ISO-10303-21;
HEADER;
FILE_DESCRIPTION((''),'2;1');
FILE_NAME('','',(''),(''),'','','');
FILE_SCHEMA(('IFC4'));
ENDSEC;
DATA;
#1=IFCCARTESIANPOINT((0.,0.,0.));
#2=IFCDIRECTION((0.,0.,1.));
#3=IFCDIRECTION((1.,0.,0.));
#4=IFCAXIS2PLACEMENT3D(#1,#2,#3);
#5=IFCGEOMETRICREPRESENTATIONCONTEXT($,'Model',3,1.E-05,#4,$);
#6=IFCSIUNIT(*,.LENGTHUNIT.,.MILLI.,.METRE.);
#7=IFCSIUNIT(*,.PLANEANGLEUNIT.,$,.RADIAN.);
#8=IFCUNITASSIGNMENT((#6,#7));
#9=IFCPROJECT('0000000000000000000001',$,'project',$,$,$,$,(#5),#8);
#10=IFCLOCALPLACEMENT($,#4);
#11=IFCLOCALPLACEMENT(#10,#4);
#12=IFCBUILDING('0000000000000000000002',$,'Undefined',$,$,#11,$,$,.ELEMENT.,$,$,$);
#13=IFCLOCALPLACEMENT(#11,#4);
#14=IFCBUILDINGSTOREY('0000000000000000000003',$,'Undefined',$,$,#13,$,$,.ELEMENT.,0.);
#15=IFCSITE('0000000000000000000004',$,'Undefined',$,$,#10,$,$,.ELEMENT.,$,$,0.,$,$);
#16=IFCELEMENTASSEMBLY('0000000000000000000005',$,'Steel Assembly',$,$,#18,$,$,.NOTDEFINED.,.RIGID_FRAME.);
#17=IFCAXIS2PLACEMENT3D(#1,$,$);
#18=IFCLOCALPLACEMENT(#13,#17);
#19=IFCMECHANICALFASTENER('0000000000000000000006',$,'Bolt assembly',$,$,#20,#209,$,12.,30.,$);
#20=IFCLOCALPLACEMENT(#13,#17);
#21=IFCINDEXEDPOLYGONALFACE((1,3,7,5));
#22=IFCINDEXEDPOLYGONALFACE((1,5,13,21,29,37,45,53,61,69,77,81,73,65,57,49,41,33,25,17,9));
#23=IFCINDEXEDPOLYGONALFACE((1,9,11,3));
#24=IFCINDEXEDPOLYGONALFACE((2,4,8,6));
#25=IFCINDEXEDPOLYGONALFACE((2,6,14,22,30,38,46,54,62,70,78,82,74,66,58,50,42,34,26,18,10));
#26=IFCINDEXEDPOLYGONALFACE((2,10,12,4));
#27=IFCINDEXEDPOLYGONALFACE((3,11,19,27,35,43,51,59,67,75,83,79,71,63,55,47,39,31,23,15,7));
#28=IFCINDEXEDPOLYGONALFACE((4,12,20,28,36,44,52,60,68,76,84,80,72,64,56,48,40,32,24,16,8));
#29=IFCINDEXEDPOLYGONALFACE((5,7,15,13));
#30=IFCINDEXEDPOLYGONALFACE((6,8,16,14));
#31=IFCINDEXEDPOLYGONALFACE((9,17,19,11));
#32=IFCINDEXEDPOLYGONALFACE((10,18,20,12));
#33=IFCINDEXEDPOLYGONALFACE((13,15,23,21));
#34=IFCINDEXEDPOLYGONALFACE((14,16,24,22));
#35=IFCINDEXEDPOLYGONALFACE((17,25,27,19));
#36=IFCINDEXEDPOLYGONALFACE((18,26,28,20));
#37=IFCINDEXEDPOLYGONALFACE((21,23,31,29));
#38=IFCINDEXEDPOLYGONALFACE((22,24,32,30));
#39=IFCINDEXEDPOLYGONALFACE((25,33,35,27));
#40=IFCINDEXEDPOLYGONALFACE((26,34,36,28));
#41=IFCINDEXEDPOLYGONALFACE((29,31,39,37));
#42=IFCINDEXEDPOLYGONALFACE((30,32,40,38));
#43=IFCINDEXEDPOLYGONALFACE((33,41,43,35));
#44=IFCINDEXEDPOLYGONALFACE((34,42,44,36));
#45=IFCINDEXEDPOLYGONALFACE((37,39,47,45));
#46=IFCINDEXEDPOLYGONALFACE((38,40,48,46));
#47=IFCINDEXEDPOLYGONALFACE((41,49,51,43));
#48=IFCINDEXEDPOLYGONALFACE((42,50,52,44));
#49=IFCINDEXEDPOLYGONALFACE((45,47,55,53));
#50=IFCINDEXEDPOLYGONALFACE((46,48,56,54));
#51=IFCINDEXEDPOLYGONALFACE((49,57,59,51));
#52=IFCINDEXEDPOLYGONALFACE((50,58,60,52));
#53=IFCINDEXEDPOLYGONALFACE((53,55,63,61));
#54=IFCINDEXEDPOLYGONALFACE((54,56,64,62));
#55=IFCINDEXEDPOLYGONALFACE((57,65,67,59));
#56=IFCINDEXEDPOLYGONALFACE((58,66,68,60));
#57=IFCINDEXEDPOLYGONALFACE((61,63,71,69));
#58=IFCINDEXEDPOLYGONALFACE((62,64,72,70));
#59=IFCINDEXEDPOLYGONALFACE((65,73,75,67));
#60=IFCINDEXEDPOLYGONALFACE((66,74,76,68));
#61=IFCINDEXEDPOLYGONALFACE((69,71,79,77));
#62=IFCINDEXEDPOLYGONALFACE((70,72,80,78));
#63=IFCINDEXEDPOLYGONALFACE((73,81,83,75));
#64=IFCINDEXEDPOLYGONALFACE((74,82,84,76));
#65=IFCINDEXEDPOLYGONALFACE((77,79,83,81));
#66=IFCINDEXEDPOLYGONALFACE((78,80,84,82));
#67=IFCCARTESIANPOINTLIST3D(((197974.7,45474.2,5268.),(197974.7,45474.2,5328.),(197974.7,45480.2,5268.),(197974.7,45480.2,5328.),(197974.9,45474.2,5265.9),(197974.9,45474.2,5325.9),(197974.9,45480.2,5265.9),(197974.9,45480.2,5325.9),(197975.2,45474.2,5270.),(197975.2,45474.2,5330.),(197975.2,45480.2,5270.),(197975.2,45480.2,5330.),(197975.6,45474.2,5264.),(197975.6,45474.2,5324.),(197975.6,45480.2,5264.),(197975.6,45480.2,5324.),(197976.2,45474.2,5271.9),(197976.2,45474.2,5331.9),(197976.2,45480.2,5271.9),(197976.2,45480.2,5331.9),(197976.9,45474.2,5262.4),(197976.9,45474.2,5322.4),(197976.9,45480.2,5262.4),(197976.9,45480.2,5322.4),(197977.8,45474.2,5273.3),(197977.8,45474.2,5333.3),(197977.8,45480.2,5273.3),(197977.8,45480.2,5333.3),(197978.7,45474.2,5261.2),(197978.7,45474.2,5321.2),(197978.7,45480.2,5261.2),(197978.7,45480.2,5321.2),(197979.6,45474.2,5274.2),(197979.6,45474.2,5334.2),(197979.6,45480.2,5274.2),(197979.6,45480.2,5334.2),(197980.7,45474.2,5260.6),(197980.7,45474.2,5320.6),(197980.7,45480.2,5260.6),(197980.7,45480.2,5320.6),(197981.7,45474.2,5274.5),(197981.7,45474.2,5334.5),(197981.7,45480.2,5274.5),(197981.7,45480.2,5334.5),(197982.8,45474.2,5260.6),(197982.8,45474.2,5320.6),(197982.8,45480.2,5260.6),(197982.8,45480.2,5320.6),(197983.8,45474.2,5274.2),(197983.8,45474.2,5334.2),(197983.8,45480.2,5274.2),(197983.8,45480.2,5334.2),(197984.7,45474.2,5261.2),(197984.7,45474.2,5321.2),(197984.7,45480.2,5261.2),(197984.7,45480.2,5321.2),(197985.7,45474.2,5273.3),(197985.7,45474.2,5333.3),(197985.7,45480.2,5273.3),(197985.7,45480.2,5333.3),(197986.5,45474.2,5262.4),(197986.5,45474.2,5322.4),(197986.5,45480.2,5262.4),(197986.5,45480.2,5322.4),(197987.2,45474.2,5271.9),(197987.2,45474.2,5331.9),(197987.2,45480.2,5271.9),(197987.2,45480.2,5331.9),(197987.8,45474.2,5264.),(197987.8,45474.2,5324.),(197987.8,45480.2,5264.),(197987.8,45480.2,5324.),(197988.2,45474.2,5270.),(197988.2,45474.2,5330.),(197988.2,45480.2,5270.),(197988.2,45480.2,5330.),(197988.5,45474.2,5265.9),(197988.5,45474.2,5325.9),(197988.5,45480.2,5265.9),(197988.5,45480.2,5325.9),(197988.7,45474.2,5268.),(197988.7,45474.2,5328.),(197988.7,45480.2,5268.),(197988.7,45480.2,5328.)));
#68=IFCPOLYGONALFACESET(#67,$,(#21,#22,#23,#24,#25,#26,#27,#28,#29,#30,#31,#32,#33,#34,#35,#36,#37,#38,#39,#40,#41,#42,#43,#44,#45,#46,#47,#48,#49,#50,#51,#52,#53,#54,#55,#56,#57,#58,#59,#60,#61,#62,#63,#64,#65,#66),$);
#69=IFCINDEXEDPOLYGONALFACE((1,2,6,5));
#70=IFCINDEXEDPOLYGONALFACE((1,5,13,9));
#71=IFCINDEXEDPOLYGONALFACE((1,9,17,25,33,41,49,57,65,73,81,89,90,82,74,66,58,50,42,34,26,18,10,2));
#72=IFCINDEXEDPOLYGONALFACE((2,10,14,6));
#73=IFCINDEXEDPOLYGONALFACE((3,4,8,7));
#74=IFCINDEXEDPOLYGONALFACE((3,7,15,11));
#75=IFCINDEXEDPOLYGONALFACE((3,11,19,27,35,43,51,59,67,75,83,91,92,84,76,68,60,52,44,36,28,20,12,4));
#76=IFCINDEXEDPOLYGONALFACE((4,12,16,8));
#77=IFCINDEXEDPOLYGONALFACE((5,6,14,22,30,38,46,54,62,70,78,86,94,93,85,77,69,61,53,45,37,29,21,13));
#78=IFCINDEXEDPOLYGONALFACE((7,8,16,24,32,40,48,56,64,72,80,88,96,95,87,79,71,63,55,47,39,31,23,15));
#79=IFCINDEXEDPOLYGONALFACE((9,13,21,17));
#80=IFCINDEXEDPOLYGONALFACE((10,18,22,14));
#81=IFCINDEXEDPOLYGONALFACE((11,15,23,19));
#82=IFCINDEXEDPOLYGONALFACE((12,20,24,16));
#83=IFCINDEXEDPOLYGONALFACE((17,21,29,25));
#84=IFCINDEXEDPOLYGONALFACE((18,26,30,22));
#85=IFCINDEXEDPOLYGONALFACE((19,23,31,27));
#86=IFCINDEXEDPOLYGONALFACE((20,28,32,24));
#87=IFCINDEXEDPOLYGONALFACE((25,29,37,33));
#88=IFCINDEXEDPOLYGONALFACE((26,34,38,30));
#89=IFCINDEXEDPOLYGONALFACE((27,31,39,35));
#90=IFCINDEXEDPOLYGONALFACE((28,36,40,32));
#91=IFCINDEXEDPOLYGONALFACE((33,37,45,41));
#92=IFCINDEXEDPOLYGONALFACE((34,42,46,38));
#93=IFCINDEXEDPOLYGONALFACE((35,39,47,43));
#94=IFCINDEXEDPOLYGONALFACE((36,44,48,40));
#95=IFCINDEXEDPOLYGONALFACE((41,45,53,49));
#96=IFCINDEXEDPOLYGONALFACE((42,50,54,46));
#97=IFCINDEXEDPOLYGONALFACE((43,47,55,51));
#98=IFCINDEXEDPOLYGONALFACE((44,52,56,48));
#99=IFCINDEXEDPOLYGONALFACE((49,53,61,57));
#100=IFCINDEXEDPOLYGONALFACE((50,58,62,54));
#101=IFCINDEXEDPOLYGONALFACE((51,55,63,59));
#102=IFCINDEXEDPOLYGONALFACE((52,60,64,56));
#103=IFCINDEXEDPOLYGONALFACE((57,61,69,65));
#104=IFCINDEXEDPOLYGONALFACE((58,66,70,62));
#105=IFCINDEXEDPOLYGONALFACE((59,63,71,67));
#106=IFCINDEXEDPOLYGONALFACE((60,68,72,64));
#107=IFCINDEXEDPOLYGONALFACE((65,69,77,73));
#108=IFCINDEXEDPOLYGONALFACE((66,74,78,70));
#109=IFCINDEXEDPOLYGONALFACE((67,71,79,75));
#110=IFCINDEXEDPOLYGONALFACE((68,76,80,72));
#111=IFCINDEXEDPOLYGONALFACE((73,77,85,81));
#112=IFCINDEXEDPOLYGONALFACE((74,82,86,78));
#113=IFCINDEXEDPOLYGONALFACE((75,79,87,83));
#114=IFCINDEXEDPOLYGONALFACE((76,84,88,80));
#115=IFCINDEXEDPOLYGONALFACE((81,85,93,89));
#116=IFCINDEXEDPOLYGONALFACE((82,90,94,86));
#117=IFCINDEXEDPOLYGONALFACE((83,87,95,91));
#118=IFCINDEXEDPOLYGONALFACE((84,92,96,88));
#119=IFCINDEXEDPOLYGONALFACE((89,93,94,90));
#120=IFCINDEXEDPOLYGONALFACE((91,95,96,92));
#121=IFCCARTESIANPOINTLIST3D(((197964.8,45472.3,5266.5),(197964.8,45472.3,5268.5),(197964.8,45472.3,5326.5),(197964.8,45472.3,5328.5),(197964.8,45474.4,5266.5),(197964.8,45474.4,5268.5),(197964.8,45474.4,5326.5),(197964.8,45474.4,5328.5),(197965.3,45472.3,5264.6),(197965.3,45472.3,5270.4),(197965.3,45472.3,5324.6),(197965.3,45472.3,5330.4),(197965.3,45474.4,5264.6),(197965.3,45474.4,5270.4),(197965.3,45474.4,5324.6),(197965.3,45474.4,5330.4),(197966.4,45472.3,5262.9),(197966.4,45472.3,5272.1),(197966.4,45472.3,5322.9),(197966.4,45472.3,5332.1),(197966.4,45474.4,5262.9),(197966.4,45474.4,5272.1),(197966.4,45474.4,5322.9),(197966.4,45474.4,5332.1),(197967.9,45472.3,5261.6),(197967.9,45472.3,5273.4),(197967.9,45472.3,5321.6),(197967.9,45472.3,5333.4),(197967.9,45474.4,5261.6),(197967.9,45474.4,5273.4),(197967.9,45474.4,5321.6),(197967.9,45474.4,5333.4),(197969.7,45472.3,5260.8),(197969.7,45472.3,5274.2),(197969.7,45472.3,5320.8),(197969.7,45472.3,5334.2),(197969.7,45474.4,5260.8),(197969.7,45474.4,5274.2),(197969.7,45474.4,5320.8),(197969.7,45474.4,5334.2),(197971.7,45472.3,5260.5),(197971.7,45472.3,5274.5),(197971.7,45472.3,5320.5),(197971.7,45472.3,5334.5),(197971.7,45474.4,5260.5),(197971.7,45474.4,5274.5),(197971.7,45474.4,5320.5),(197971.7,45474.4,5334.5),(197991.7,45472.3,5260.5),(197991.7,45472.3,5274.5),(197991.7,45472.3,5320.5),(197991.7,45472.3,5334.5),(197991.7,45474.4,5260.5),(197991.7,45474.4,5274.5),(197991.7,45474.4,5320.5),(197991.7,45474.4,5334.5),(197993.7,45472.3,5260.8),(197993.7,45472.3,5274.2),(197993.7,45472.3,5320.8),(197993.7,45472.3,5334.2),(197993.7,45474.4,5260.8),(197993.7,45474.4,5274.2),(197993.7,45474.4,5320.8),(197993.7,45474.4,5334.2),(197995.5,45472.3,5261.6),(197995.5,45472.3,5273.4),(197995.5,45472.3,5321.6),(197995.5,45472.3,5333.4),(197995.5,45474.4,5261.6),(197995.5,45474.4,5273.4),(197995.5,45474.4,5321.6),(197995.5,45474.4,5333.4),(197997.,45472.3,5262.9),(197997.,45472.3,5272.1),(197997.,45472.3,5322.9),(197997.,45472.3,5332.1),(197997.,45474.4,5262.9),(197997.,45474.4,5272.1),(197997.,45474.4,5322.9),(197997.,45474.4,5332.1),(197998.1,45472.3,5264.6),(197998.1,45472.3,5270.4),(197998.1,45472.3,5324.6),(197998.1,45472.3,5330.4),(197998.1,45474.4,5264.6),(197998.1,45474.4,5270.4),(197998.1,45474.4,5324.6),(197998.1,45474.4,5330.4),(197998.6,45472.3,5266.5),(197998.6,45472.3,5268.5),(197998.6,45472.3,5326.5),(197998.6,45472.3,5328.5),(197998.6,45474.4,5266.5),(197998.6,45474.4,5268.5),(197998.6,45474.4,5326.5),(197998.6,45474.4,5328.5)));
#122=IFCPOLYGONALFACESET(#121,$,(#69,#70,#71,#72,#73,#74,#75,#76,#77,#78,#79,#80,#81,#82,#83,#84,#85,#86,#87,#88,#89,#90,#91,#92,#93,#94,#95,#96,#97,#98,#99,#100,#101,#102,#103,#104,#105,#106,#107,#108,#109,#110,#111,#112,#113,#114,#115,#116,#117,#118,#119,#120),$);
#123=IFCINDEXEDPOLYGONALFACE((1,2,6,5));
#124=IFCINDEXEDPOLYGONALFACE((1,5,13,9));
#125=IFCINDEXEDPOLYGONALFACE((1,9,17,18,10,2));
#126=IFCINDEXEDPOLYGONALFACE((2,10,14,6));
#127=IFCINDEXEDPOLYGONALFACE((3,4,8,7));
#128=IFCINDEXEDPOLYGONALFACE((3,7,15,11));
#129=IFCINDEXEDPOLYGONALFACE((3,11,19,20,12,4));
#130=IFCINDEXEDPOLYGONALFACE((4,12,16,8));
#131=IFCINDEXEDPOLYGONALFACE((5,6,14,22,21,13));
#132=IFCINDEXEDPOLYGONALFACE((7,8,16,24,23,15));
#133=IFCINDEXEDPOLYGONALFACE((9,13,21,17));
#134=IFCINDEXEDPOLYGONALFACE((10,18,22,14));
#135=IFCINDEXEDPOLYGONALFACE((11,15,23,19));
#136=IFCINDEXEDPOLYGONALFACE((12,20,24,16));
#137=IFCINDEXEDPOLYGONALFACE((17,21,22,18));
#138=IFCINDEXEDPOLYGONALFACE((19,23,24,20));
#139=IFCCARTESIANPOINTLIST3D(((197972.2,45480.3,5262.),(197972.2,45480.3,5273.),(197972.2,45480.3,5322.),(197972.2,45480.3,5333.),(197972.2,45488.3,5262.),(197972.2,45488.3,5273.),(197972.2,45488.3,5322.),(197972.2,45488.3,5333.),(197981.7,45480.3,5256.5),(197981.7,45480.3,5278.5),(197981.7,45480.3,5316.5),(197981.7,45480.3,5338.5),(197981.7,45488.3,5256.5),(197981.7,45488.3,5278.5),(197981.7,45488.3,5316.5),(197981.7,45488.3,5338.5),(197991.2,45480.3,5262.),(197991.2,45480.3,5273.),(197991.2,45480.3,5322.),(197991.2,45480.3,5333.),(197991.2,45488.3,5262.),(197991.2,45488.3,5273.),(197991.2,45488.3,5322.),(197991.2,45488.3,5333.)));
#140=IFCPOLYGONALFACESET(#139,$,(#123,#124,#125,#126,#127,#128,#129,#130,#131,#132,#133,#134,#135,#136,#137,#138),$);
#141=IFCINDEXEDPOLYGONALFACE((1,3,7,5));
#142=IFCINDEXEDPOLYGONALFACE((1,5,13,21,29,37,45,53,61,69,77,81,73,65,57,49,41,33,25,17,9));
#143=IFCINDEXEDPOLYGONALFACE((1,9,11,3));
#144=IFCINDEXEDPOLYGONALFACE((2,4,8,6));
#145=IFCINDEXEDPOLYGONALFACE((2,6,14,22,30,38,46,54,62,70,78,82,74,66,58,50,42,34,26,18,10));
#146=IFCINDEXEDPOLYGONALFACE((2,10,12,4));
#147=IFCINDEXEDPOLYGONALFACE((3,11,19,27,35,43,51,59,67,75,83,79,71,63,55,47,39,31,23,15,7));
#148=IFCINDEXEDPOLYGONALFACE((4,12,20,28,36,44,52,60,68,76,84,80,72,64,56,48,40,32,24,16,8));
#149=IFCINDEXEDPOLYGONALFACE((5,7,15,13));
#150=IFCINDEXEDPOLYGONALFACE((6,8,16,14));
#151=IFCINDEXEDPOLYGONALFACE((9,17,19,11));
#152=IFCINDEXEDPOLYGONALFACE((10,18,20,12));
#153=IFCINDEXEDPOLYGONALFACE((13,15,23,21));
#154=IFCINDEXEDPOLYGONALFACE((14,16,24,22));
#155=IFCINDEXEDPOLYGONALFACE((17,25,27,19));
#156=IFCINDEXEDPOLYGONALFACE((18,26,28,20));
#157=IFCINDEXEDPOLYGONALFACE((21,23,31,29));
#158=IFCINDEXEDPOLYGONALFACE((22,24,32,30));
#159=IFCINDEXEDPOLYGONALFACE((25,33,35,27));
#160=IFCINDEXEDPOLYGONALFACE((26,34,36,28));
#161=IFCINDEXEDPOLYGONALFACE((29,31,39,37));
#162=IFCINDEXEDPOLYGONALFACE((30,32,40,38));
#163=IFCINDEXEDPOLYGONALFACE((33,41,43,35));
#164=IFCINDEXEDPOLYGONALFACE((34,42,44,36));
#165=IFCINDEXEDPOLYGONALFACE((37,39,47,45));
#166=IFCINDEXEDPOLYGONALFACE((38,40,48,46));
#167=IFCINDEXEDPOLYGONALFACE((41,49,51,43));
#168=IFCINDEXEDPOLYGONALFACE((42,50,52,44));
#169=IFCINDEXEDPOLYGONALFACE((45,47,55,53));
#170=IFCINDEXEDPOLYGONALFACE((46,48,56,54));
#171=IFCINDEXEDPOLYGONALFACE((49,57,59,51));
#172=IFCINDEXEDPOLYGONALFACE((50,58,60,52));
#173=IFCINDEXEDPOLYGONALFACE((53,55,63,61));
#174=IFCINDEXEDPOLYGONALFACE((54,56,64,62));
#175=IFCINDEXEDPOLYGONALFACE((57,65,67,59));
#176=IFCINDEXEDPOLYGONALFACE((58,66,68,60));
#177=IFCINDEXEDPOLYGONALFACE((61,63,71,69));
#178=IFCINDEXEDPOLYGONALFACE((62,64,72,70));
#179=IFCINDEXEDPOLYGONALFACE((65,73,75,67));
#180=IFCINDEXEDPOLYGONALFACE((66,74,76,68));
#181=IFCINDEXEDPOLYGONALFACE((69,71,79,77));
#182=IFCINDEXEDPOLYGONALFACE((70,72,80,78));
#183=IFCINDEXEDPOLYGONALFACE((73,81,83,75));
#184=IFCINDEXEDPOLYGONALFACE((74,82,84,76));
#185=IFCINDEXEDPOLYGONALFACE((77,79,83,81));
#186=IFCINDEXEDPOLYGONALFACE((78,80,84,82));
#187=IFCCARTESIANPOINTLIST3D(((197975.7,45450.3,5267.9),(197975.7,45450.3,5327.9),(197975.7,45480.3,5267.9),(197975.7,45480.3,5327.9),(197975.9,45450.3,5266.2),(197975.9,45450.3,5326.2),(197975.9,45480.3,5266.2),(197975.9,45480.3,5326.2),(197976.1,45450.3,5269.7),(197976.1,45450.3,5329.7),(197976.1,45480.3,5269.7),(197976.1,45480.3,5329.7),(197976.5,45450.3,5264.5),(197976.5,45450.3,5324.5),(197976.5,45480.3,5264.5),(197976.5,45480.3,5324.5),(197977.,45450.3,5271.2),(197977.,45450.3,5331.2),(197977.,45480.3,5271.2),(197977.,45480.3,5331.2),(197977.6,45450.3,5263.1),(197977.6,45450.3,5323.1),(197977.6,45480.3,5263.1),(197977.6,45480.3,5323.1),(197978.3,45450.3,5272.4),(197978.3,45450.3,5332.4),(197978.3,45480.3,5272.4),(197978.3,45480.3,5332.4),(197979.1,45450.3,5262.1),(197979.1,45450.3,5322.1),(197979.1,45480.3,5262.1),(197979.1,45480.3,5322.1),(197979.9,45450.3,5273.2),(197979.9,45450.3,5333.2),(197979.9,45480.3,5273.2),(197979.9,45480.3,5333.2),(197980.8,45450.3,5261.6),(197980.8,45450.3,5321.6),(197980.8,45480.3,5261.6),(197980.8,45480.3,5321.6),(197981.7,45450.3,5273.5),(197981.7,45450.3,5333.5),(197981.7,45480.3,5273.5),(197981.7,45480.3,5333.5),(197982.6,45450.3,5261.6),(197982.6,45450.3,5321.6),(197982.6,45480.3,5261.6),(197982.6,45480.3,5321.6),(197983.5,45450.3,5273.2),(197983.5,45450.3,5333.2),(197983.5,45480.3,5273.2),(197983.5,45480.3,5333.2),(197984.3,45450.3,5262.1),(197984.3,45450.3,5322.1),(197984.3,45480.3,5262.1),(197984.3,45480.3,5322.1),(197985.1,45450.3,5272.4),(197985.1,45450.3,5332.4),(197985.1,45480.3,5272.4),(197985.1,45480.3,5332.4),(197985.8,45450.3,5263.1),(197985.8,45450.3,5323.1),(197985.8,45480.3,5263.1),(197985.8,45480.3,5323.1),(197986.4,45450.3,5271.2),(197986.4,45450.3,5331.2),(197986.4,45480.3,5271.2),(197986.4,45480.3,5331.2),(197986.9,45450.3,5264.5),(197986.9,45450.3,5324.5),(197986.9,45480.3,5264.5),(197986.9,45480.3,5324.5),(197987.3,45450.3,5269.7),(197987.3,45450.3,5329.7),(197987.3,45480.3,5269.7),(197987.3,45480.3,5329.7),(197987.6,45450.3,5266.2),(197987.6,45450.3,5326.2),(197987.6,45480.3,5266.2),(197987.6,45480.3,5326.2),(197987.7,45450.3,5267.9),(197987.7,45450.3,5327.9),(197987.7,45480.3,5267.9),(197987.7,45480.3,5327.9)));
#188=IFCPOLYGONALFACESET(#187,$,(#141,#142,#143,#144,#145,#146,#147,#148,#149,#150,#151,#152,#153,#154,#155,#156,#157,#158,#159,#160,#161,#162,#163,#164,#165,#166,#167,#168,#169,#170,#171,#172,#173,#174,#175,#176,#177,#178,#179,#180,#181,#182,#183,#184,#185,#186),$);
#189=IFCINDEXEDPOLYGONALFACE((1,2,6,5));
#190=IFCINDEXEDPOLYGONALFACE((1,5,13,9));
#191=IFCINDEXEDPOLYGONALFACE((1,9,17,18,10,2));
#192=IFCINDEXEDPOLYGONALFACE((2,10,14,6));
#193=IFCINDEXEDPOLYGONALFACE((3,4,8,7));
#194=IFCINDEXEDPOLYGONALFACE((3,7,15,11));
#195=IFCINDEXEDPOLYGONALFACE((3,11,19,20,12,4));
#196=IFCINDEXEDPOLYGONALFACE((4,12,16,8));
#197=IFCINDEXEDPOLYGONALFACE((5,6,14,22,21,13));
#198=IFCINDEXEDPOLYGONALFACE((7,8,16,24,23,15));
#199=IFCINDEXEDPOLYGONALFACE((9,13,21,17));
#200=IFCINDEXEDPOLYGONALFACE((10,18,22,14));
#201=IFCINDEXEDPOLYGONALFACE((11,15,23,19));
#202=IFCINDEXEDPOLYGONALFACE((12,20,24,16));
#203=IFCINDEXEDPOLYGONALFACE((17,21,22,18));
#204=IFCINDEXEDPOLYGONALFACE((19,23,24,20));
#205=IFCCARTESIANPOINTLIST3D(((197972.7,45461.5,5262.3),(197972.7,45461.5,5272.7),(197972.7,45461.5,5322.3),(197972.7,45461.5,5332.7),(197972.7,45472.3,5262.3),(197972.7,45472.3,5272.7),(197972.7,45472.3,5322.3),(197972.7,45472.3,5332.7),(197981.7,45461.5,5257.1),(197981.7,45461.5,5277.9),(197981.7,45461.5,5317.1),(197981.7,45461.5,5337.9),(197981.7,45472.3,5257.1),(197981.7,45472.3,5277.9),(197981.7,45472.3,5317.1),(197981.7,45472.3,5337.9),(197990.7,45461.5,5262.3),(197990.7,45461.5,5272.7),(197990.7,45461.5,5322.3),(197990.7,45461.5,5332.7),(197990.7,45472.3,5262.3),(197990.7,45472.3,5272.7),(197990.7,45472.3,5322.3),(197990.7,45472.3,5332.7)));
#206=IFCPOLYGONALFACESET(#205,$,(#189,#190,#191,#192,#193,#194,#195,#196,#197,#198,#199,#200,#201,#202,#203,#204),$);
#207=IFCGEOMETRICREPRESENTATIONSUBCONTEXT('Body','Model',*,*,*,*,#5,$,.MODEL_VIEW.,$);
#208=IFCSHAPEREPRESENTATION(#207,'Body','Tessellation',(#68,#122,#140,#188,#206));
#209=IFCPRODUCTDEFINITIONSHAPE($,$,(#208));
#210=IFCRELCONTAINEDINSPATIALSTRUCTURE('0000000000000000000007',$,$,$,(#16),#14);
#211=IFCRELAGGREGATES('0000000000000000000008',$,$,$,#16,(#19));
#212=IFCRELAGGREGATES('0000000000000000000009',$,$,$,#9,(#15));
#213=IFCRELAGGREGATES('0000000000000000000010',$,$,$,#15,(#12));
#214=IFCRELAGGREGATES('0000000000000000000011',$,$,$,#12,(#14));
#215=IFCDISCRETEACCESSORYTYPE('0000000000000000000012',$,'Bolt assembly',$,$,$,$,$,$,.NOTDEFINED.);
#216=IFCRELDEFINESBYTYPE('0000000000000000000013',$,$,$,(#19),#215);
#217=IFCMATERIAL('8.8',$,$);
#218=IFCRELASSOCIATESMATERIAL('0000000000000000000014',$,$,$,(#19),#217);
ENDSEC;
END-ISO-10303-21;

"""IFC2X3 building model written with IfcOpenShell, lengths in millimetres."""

from ifc_helpers import new_model, si_unit, frame, frame_2d, origin_with_axes, origin_2d_with_axis, place, context, subcontext, project, spatial, polyline, circle_curve, parameter, trimmed, segment, composite_curve, circle, outline, extrude, source, transform, mapped, material, type_object, element, aggregate, save


model = new_model("IFC2X3")

# Units and contexts
model_context = context("Model", 3, precision=1e-05, world=origin_with_axes())
body_context = subcontext(model_context, "Body", "Model", "MODEL_VIEW")
ifc_project = project(units=[si_unit("LENGTHUNIT", "METRE", prefix="MILLI"), si_unit("PLANEANGLEUNIT", "RADIAN")], contexts=[model_context])

# Site, building, storey
site_placement = place(None, origin_with_axes())
site = spatial("IfcSite", under=ifc_project, at=site_placement, Name="Undefined", CompositionType="ELEMENT", RefElevation=0.0)
building_placement = place(site_placement, origin_with_axes())
building = spatial("IfcBuilding", under=site, at=building_placement, Name="Undefined", CompositionType="ELEMENT")
storey_placement = place(building_placement, origin_with_axes())
storey = spatial("IfcBuildingStorey", under=building, at=storey_placement, Name="Undefined", CompositionType="ELEMENT", Elevation=0.0)

# Shared definitions
discrete_accessory_type_1 = type_object("IfcDiscreteAccessoryType", Name="Bolt assembly")
ifc_material_1 = material(Name="8.8")

# Element assembly, mechanical fastener
assembly_1_placement = place(storey_placement, origin_with_axes())
assembly_1 = element("IfcElementAssembly", 1, at=assembly_1_placement, inside=storey, Name="Steel Assembly", AssemblyPlace="NOTDEFINED", PredefinedType="RIGID_FRAME")
shared_shape_1 = source(origin_with_axes(), body_context, "Body", "SweptSolid", [
    extrude(circle(Radius=7.0, at=origin_2d_with_axis()), frame((0.0, -2.9, 0.0), z_axis=(0.0, 1.0, 0.0), x_axis=(1.0, 0.0, 0.0)), (0.0, 0.0, 1.0), 6.0),
    extrude(outline(composite_curve([segment(polyline([(7.0, 10.0), (7.0, -10.0)]), True, "CONTINUOUS"), segment(trimmed(circle_curve(frame_2d((0.0, -10.0), x_axis=(1.0, 0.0)), 7.0), [parameter(0.0)], [parameter(3.1416)], False, "PARAMETER"), True, "CONTINUOUS"), segment(polyline([(-7.0, -10.0), (-7.0, 10.0)]), True, "CONTINUOUS"), segment(trimmed(circle_curve(frame_2d((0.0, 10.0), x_axis=(-1.0, 0.0)), 7.0), [parameter(0.0)], [parameter(3.1416)], False, "PARAMETER"), True, "DISCONTINUOUS")], self_intersect=False)), frame((0.0, 2.9, 0.0), z_axis=(0.0, 1.0, 0.0), x_axis=(1.0, 0.0, 0.0)), (0.0, 0.0, 1.0), 2.1),
    extrude(outline(polyline([(11.0, 0.0), (5.5, 9.5), (-5.5, 9.5), (-11.0, 0.0), (-5.5, -9.5), (5.5, -9.5), (11.0, 0.0)])), frame((0.0, -11.0, 0.0), z_axis=(0.0, 1.0, 0.0), x_axis=(1.0, 0.0, 0.0)), (0.0, 0.0, 1.0), 8.0),
    extrude(circle(Radius=6.0, at=origin_2d_with_axis()), frame((0.0, -3.0, 0.0), z_axis=(0.0, 1.0, 0.0), x_axis=(1.0, 0.0, 0.0)), (0.0, 0.0, 1.0), 30.0),
    extrude(outline(polyline([(10.4, 0.0), (5.2, 9.0), (-5.2, 9.0), (-10.4, 0.0), (-5.2, -9.0), (5.2, -9.0), (10.4, 0.0)])), frame((0.0, 5.0, 0.0), z_axis=(0.0, 1.0, 0.0), x_axis=(1.0, 0.0, 0.0)), (0.0, 0.0, 1.0), 10.8),
])
mechanical_fastener_1_placement = place(assembly_1_placement, frame((197936.7, 45477.3, 5222.5), z_axis=(1.0, 0.0, 0.0), x_axis=(0.0, 0.0, 1.0)))
mechanical_fastener_1 = element("IfcMechanicalFastener", 2, at=mechanical_fastener_1_placement, type_object=discrete_accessory_type_1, material=ifc_material_1, Name="Bolt assembly", NominalDiameter=12.0, NominalLength=30.0, context=body_context, shape_type="MappedRepresentation", body=[
    mapped(shared_shape_1, transform((45.0, 0.0, 45.0))),
    mapped(shared_shape_1, transform((105.0, 0.0, 45.0))),
])
aggregate(assembly_1, [mechanical_fastener_1])

save(model, "model.ifc")
